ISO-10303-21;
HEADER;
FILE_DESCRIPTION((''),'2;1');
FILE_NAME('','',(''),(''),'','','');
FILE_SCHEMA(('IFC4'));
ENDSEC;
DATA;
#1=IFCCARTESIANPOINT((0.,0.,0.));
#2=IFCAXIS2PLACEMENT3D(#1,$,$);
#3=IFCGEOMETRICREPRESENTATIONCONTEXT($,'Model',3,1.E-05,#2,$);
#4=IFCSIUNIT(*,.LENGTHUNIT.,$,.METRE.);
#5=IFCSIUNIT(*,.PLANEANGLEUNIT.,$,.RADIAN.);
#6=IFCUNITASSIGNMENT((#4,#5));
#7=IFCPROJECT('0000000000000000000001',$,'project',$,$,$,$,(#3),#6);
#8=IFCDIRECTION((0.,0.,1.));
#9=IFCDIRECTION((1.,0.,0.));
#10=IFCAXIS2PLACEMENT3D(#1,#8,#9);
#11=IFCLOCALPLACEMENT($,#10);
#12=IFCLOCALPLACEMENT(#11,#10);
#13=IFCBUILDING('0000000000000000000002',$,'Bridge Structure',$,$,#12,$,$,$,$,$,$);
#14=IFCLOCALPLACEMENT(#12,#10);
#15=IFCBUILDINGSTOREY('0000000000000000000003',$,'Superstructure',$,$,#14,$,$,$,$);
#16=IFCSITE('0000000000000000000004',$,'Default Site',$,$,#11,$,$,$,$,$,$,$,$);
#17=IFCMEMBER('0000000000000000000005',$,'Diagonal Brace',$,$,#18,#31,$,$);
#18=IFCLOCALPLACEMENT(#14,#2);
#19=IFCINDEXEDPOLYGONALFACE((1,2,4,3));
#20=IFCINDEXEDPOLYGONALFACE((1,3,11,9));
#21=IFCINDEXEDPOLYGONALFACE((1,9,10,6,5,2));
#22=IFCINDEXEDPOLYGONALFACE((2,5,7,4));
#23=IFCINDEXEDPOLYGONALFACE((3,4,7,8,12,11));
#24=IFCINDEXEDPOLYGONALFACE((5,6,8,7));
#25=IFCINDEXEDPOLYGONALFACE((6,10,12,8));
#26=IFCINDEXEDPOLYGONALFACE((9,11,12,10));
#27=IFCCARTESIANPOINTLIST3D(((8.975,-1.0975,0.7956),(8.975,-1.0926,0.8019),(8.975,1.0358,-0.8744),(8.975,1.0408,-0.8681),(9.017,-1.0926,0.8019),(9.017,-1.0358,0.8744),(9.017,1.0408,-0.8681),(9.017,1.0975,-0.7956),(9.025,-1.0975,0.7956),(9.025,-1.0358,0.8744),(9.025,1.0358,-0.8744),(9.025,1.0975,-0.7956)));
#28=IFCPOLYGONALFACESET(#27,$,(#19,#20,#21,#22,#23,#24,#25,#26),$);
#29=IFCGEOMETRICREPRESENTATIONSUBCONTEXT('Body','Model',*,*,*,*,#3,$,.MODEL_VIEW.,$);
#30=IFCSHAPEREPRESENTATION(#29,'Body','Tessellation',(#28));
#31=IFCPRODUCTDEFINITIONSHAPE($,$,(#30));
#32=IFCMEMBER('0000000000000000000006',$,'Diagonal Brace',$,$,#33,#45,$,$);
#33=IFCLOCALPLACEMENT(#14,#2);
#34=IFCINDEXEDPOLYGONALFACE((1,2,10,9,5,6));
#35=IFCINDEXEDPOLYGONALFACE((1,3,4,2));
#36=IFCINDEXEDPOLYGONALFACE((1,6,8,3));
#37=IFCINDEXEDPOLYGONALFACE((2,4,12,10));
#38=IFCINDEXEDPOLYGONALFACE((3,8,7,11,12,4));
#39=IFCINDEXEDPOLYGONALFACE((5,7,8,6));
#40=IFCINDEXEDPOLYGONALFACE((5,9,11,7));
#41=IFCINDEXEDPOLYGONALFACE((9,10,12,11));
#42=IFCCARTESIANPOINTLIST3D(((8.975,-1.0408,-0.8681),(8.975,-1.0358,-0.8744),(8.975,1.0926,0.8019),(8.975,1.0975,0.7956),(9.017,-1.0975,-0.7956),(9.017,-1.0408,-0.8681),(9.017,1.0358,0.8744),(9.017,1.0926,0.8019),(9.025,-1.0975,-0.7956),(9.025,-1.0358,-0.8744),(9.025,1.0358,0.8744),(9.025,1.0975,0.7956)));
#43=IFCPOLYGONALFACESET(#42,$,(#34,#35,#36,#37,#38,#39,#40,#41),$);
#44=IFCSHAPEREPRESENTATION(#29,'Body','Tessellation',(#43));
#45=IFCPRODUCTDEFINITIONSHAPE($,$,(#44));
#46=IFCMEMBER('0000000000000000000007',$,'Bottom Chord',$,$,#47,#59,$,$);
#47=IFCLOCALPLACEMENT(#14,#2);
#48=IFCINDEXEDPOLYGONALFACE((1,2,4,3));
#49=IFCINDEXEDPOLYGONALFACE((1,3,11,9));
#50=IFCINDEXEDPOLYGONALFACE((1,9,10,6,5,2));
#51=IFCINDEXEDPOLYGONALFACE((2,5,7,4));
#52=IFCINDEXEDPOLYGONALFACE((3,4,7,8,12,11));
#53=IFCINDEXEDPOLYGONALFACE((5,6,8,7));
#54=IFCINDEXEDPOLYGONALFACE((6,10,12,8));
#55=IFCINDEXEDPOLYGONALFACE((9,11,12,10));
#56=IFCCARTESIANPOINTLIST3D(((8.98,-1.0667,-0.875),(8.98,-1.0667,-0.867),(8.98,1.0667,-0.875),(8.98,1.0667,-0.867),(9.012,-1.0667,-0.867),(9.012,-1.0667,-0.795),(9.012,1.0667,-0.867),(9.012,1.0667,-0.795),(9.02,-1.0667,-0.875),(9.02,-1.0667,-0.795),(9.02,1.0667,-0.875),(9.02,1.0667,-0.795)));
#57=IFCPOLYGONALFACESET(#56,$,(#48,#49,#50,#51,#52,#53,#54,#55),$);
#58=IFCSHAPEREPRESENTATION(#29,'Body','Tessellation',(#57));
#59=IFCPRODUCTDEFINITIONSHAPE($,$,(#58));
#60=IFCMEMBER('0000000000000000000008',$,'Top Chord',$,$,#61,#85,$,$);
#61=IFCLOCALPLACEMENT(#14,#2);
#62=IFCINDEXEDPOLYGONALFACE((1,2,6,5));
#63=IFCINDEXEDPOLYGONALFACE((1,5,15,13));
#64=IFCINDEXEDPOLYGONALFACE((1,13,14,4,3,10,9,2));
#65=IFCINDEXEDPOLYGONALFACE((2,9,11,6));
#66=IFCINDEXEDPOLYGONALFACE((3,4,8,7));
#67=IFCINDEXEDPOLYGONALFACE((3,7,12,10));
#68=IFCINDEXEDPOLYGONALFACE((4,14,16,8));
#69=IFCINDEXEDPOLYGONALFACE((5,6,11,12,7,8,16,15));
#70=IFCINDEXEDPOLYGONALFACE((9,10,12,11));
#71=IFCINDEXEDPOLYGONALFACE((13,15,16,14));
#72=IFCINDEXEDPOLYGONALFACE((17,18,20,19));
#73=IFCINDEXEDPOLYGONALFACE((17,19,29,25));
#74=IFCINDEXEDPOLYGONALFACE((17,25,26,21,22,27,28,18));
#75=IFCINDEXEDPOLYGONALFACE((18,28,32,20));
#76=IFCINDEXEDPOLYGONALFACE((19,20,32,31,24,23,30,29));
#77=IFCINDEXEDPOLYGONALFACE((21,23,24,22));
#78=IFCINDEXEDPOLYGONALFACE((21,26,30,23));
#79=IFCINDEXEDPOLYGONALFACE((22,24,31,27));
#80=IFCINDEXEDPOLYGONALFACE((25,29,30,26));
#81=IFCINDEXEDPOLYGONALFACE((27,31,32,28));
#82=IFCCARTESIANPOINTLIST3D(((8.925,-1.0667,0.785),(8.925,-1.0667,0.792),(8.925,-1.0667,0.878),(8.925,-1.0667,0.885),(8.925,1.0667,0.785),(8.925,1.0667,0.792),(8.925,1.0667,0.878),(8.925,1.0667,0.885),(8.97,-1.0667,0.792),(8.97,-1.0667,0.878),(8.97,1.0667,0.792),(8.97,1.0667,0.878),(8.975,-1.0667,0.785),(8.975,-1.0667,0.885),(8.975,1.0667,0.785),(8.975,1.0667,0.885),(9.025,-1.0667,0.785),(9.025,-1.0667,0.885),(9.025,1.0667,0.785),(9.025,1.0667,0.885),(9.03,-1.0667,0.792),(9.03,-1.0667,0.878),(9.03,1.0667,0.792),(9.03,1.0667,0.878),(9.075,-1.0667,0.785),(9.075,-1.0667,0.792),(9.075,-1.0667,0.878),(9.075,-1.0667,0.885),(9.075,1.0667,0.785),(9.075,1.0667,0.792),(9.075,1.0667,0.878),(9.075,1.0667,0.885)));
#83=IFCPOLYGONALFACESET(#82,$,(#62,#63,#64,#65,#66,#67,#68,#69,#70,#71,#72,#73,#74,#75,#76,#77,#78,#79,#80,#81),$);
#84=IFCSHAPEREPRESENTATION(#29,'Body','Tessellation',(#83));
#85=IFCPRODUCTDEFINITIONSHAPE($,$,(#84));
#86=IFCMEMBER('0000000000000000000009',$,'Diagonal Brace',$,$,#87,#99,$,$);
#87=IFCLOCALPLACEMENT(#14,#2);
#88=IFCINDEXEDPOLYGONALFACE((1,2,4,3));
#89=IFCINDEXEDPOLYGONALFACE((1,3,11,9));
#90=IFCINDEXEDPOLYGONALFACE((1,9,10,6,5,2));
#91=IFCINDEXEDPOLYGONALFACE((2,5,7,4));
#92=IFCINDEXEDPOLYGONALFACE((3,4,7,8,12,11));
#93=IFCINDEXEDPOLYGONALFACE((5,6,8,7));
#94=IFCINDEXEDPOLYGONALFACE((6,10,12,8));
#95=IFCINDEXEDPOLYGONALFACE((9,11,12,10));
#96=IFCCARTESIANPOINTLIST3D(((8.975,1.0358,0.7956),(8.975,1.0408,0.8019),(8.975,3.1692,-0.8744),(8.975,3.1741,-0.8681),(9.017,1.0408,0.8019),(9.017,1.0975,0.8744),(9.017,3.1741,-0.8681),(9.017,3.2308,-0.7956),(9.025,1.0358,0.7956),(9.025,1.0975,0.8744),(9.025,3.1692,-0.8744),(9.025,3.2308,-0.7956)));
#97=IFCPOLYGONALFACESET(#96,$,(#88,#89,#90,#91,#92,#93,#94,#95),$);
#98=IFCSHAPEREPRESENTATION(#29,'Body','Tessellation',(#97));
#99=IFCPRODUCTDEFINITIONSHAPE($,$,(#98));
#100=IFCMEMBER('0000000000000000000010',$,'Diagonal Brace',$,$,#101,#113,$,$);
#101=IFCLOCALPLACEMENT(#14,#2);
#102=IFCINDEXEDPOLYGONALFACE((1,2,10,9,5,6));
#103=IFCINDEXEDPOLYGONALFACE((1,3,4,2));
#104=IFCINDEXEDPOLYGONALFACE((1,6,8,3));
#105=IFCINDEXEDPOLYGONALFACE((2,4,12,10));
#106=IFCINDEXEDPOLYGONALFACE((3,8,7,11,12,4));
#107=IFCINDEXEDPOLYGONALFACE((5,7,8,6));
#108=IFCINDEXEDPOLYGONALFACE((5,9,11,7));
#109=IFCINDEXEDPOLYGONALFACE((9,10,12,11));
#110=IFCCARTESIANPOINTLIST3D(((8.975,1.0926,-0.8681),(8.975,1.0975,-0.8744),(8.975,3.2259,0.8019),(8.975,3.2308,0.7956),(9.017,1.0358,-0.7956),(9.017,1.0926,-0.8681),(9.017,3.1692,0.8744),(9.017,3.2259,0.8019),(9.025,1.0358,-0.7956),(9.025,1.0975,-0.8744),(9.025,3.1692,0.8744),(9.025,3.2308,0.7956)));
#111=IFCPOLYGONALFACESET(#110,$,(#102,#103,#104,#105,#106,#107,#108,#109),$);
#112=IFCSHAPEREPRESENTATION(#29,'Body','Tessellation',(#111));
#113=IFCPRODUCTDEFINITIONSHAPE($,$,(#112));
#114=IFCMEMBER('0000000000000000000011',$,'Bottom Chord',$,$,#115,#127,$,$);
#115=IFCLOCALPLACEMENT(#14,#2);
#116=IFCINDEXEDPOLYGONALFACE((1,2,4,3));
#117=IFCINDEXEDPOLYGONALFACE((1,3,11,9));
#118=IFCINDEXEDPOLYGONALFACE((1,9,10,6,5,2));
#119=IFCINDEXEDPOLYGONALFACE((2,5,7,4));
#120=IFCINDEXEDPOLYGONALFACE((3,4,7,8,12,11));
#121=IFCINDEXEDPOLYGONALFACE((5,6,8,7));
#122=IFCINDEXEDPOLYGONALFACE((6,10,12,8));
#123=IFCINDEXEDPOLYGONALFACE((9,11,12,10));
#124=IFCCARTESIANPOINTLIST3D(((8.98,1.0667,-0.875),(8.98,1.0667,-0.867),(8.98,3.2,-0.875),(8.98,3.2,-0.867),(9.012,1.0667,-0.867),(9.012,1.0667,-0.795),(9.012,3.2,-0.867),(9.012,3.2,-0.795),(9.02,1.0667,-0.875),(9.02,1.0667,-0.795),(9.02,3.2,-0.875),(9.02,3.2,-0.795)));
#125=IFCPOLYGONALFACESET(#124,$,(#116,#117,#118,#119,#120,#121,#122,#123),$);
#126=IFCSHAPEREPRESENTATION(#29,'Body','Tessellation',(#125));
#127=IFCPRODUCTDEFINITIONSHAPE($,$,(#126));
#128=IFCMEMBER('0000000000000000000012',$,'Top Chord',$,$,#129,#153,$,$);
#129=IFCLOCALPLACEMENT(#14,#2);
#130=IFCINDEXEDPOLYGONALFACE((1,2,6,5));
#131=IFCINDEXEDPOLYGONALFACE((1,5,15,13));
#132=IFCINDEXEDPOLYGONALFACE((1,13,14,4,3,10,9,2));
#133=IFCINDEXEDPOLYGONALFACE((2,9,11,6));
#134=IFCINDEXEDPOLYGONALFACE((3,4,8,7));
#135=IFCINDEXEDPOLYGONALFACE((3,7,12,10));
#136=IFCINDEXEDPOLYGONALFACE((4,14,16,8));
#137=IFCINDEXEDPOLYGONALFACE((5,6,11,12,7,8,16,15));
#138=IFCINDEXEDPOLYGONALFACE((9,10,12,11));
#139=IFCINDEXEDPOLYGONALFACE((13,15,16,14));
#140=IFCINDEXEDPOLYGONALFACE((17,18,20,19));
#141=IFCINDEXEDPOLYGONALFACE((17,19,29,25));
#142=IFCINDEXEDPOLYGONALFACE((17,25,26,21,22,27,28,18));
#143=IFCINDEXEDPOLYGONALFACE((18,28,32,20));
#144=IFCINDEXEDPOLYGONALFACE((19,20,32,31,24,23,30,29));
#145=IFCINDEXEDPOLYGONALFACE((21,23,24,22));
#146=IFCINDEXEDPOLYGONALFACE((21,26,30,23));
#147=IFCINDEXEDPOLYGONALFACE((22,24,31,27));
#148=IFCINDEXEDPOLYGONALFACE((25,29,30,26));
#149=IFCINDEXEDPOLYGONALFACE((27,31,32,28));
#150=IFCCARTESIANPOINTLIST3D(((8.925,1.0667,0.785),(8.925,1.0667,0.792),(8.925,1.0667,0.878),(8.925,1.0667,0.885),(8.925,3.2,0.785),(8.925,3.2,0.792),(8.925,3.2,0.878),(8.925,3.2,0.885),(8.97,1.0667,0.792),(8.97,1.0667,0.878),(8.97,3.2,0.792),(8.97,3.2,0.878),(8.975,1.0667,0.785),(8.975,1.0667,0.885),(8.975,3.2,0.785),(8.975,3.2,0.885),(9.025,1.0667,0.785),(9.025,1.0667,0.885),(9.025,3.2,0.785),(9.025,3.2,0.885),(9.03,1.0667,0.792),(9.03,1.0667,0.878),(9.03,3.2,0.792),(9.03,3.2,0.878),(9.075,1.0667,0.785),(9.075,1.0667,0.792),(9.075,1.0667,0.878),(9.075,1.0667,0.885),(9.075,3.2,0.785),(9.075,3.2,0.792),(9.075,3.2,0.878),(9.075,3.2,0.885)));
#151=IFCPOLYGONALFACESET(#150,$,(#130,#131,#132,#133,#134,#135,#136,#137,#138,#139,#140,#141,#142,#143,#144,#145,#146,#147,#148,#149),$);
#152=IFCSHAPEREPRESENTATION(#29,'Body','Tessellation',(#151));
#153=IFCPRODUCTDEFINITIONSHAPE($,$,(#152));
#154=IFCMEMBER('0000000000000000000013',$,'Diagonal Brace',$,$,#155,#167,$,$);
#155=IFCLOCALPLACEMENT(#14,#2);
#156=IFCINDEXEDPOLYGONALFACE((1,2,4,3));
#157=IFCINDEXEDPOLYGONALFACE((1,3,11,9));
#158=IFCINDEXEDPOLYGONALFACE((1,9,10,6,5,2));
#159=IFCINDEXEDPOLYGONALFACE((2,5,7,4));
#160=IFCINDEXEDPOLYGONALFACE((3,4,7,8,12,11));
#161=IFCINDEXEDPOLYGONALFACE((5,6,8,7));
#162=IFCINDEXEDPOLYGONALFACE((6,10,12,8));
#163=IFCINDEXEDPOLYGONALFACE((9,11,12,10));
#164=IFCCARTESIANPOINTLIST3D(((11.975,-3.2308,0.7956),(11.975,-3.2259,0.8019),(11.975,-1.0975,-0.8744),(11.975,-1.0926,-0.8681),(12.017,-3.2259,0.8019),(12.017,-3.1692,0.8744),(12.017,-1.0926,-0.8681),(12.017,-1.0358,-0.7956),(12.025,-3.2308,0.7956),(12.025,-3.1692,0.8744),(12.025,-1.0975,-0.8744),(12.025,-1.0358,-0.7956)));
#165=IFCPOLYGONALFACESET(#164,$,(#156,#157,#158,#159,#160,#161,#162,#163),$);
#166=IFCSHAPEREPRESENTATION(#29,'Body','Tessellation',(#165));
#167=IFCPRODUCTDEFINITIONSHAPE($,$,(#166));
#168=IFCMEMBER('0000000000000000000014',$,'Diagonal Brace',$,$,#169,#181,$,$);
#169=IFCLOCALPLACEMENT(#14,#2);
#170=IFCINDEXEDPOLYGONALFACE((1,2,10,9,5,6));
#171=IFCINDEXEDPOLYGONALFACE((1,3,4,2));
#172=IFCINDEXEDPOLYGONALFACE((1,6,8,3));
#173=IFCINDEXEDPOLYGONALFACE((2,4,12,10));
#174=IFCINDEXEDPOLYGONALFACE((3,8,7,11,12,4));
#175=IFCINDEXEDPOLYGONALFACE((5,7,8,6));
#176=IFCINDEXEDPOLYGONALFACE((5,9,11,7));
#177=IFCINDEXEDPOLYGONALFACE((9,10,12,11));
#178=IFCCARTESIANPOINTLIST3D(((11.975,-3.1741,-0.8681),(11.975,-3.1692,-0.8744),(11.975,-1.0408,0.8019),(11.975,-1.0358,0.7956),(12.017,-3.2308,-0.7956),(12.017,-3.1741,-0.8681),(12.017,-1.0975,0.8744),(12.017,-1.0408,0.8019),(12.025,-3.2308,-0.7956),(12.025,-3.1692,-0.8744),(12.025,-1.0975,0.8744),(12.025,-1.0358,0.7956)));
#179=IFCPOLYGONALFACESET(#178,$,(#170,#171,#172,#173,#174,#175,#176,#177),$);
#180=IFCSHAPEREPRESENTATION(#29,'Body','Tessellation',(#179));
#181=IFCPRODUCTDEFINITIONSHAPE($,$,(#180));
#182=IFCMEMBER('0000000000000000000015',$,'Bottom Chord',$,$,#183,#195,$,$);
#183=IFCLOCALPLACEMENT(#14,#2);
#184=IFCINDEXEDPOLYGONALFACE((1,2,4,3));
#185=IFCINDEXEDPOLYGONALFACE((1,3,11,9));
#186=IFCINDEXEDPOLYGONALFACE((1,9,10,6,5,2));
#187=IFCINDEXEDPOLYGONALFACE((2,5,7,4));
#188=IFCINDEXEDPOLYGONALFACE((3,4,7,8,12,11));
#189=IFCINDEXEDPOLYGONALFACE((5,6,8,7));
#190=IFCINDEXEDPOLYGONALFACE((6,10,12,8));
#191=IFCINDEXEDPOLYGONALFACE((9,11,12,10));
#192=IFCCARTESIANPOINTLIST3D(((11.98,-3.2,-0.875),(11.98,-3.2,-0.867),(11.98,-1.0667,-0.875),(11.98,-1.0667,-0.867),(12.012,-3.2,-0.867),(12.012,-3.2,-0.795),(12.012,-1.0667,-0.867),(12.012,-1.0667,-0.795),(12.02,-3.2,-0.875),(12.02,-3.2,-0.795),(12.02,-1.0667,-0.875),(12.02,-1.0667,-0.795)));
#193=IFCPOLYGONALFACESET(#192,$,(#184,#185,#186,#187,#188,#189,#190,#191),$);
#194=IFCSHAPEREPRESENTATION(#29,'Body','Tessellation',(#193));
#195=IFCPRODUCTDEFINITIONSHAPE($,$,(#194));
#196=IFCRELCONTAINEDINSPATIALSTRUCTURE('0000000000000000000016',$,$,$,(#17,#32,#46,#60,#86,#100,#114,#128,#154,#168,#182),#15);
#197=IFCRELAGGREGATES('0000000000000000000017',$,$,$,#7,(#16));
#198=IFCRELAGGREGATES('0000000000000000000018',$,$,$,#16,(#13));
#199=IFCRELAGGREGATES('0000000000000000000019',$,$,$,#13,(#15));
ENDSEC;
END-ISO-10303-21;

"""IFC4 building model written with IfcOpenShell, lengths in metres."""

from ifc_helpers import new_model, si_unit, frame, origin, origin_with_axes, origin_2d_with_axis, place, context, subcontext, project, spatial, polyline, l_section, outline, composite_profile, extrude, element, save


model = new_model("IFC4")

# Units and contexts
model_context = context("Model", 3, precision=1e-05, world=origin())
body_context = subcontext(model_context, "Body", "Model", "MODEL_VIEW")
ifc_project = project(units=[si_unit("LENGTHUNIT", "METRE"), si_unit("PLANEANGLEUNIT", "RADIAN")], contexts=[model_context])

# Site, building, storey
site_placement = place(None, origin_with_axes())
site = spatial("IfcSite", under=ifc_project, at=site_placement, Name="Default Site")
building_placement = place(site_placement, origin_with_axes())
building = spatial("IfcBuilding", under=site, at=building_placement, Name="Bridge Structure")
storey_placement = place(building_placement, origin_with_axes())
storey = spatial("IfcBuildingStorey", under=building, at=storey_placement, Name="Superstructure")

# Members
for number, where, z_axis, x_axis, name in (
    (1, (9.0, -1.0667, 0.835), (0.0, 0.787427, -0.616408), (-1.0, 0.0, 0.0), "Diagonal Brace"),
    (2, (9.0, -1.0667, -0.835), (0.0, 0.787427, 0.616408), (-1.0, 0.0, 0.0), "Diagonal Brace"),
):
    element("IfcMember", number, at=place(storey_placement, frame(where, z_axis=z_axis, x_axis=x_axis)), inside=storey, Name=name, context=body_context, shape_type="SweptSolid", body=[
        extrude(l_section(Depth=0.1, Width=0.05, Thickness=0.008, at=origin_2d_with_axis()), origin_with_axes(), (0.0, 0.0, 1.0), 2.7092),
    ])
member_1_placement = place(storey_placement, frame((9.0, -1.0667, -0.835), z_axis=(0.0, 1.0, 0.0), x_axis=(-1.0, 0.0, 0.0)))
element("IfcMember", 3, at=member_1_placement, inside=storey, Name="Bottom Chord", context=body_context, shape_type="SweptSolid", body=[
    extrude(l_section(Depth=0.08, Width=0.04, Thickness=0.008, at=origin_2d_with_axis()), origin_with_axes(), (0.0, 0.0, 1.0), 2.1333),
])
member_2_placement = place(storey_placement, frame((9.0, -1.0667, 0.835), z_axis=(0.0, 1.0, 0.0), x_axis=(-1.0, 0.0, 0.0)))
element("IfcMember", 4, at=member_2_placement, inside=storey, Name="Top Chord", context=body_context, shape_type="SweptSolid", body=[
    extrude(composite_profile([outline(polyline([(-0.025, -0.05), (-0.025, 0.05), (-0.075, 0.05), (-0.075, 0.043), (-0.03, 0.043), (-0.03, -0.043), (-0.075, -0.043), (-0.075, -0.05), (-0.025, -0.05)])), outline(polyline([(0.025, -0.05), (0.075, -0.05), (0.075, -0.043), (0.03, -0.043), (0.03, 0.043), (0.075, 0.043), (0.075, 0.05), (0.025, 0.05), (0.025, -0.05)]))]), origin_with_axes(), (0.0, 0.0, 1.0), 2.1333),
])
for number, where, z_axis, x_axis, name in (
    (5, (9.0, 1.0667, 0.835), (0.0, 0.787427, -0.616408), (-1.0, 0.0, 0.0), "Diagonal Brace"),
    (6, (9.0, 1.0667, -0.835), (0.0, 0.787427, 0.616408), (-1.0, 0.0, 0.0), "Diagonal Brace"),
):
    element("IfcMember", number, at=place(storey_placement, frame(where, z_axis=z_axis, x_axis=x_axis)), inside=storey, Name=name, context=body_context, shape_type="SweptSolid", body=[
        extrude(l_section(Depth=0.1, Width=0.05, Thickness=0.008, at=origin_2d_with_axis()), origin_with_axes(), (0.0, 0.0, 1.0), 2.7092),
    ])
member_3_placement = place(storey_placement, frame((9.0, 1.0667, -0.835), z_axis=(0.0, 1.0, 0.0), x_axis=(-1.0, 0.0, 0.0)))
element("IfcMember", 7, at=member_3_placement, inside=storey, Name="Bottom Chord", context=body_context, shape_type="SweptSolid", body=[
    extrude(l_section(Depth=0.08, Width=0.04, Thickness=0.008, at=origin_2d_with_axis()), origin_with_axes(), (0.0, 0.0, 1.0), 2.1333),
])
member_4_placement = place(storey_placement, frame((9.0, 1.0667, 0.835), z_axis=(0.0, 1.0, 0.0), x_axis=(-1.0, 0.0, 0.0)))
element("IfcMember", 8, at=member_4_placement, inside=storey, Name="Top Chord", context=body_context, shape_type="SweptSolid", body=[
    extrude(composite_profile([outline(polyline([(-0.025, -0.05), (-0.025, 0.05), (-0.075, 0.05), (-0.075, 0.043), (-0.03, 0.043), (-0.03, -0.043), (-0.075, -0.043), (-0.075, -0.05), (-0.025, -0.05)])), outline(polyline([(0.025, -0.05), (0.075, -0.05), (0.075, -0.043), (0.03, -0.043), (0.03, 0.043), (0.075, 0.043), (0.075, 0.05), (0.025, 0.05), (0.025, -0.05)]))]), origin_with_axes(), (0.0, 0.0, 1.0), 2.1333),
])
for number, where, z_axis, x_axis, name in (
    (9, (12.0, -3.2, 0.835), (0.0, 0.787427, -0.616408), (-1.0, 0.0, 0.0), "Diagonal Brace"),
    (10, (12.0, -3.2, -0.835), (0.0, 0.787427, 0.616408), (-1.0, 0.0, 0.0), "Diagonal Brace"),
):
    element("IfcMember", number, at=place(storey_placement, frame(where, z_axis=z_axis, x_axis=x_axis)), inside=storey, Name=name, context=body_context, shape_type="SweptSolid", body=[
        extrude(l_section(Depth=0.1, Width=0.05, Thickness=0.008, at=origin_2d_with_axis()), origin_with_axes(), (0.0, 0.0, 1.0), 2.7092),
    ])
member_5_placement = place(storey_placement, frame((12.0, -3.2, -0.835), z_axis=(0.0, 1.0, 0.0), x_axis=(-1.0, 0.0, 0.0)))
element("IfcMember", 11, at=member_5_placement, inside=storey, Name="Bottom Chord", context=body_context, shape_type="SweptSolid", body=[
    extrude(l_section(Depth=0.08, Width=0.04, Thickness=0.008, at=origin_2d_with_axis()), origin_with_axes(), (0.0, 0.0, 1.0), 2.1333),
])

save(model, "model.ifc")
